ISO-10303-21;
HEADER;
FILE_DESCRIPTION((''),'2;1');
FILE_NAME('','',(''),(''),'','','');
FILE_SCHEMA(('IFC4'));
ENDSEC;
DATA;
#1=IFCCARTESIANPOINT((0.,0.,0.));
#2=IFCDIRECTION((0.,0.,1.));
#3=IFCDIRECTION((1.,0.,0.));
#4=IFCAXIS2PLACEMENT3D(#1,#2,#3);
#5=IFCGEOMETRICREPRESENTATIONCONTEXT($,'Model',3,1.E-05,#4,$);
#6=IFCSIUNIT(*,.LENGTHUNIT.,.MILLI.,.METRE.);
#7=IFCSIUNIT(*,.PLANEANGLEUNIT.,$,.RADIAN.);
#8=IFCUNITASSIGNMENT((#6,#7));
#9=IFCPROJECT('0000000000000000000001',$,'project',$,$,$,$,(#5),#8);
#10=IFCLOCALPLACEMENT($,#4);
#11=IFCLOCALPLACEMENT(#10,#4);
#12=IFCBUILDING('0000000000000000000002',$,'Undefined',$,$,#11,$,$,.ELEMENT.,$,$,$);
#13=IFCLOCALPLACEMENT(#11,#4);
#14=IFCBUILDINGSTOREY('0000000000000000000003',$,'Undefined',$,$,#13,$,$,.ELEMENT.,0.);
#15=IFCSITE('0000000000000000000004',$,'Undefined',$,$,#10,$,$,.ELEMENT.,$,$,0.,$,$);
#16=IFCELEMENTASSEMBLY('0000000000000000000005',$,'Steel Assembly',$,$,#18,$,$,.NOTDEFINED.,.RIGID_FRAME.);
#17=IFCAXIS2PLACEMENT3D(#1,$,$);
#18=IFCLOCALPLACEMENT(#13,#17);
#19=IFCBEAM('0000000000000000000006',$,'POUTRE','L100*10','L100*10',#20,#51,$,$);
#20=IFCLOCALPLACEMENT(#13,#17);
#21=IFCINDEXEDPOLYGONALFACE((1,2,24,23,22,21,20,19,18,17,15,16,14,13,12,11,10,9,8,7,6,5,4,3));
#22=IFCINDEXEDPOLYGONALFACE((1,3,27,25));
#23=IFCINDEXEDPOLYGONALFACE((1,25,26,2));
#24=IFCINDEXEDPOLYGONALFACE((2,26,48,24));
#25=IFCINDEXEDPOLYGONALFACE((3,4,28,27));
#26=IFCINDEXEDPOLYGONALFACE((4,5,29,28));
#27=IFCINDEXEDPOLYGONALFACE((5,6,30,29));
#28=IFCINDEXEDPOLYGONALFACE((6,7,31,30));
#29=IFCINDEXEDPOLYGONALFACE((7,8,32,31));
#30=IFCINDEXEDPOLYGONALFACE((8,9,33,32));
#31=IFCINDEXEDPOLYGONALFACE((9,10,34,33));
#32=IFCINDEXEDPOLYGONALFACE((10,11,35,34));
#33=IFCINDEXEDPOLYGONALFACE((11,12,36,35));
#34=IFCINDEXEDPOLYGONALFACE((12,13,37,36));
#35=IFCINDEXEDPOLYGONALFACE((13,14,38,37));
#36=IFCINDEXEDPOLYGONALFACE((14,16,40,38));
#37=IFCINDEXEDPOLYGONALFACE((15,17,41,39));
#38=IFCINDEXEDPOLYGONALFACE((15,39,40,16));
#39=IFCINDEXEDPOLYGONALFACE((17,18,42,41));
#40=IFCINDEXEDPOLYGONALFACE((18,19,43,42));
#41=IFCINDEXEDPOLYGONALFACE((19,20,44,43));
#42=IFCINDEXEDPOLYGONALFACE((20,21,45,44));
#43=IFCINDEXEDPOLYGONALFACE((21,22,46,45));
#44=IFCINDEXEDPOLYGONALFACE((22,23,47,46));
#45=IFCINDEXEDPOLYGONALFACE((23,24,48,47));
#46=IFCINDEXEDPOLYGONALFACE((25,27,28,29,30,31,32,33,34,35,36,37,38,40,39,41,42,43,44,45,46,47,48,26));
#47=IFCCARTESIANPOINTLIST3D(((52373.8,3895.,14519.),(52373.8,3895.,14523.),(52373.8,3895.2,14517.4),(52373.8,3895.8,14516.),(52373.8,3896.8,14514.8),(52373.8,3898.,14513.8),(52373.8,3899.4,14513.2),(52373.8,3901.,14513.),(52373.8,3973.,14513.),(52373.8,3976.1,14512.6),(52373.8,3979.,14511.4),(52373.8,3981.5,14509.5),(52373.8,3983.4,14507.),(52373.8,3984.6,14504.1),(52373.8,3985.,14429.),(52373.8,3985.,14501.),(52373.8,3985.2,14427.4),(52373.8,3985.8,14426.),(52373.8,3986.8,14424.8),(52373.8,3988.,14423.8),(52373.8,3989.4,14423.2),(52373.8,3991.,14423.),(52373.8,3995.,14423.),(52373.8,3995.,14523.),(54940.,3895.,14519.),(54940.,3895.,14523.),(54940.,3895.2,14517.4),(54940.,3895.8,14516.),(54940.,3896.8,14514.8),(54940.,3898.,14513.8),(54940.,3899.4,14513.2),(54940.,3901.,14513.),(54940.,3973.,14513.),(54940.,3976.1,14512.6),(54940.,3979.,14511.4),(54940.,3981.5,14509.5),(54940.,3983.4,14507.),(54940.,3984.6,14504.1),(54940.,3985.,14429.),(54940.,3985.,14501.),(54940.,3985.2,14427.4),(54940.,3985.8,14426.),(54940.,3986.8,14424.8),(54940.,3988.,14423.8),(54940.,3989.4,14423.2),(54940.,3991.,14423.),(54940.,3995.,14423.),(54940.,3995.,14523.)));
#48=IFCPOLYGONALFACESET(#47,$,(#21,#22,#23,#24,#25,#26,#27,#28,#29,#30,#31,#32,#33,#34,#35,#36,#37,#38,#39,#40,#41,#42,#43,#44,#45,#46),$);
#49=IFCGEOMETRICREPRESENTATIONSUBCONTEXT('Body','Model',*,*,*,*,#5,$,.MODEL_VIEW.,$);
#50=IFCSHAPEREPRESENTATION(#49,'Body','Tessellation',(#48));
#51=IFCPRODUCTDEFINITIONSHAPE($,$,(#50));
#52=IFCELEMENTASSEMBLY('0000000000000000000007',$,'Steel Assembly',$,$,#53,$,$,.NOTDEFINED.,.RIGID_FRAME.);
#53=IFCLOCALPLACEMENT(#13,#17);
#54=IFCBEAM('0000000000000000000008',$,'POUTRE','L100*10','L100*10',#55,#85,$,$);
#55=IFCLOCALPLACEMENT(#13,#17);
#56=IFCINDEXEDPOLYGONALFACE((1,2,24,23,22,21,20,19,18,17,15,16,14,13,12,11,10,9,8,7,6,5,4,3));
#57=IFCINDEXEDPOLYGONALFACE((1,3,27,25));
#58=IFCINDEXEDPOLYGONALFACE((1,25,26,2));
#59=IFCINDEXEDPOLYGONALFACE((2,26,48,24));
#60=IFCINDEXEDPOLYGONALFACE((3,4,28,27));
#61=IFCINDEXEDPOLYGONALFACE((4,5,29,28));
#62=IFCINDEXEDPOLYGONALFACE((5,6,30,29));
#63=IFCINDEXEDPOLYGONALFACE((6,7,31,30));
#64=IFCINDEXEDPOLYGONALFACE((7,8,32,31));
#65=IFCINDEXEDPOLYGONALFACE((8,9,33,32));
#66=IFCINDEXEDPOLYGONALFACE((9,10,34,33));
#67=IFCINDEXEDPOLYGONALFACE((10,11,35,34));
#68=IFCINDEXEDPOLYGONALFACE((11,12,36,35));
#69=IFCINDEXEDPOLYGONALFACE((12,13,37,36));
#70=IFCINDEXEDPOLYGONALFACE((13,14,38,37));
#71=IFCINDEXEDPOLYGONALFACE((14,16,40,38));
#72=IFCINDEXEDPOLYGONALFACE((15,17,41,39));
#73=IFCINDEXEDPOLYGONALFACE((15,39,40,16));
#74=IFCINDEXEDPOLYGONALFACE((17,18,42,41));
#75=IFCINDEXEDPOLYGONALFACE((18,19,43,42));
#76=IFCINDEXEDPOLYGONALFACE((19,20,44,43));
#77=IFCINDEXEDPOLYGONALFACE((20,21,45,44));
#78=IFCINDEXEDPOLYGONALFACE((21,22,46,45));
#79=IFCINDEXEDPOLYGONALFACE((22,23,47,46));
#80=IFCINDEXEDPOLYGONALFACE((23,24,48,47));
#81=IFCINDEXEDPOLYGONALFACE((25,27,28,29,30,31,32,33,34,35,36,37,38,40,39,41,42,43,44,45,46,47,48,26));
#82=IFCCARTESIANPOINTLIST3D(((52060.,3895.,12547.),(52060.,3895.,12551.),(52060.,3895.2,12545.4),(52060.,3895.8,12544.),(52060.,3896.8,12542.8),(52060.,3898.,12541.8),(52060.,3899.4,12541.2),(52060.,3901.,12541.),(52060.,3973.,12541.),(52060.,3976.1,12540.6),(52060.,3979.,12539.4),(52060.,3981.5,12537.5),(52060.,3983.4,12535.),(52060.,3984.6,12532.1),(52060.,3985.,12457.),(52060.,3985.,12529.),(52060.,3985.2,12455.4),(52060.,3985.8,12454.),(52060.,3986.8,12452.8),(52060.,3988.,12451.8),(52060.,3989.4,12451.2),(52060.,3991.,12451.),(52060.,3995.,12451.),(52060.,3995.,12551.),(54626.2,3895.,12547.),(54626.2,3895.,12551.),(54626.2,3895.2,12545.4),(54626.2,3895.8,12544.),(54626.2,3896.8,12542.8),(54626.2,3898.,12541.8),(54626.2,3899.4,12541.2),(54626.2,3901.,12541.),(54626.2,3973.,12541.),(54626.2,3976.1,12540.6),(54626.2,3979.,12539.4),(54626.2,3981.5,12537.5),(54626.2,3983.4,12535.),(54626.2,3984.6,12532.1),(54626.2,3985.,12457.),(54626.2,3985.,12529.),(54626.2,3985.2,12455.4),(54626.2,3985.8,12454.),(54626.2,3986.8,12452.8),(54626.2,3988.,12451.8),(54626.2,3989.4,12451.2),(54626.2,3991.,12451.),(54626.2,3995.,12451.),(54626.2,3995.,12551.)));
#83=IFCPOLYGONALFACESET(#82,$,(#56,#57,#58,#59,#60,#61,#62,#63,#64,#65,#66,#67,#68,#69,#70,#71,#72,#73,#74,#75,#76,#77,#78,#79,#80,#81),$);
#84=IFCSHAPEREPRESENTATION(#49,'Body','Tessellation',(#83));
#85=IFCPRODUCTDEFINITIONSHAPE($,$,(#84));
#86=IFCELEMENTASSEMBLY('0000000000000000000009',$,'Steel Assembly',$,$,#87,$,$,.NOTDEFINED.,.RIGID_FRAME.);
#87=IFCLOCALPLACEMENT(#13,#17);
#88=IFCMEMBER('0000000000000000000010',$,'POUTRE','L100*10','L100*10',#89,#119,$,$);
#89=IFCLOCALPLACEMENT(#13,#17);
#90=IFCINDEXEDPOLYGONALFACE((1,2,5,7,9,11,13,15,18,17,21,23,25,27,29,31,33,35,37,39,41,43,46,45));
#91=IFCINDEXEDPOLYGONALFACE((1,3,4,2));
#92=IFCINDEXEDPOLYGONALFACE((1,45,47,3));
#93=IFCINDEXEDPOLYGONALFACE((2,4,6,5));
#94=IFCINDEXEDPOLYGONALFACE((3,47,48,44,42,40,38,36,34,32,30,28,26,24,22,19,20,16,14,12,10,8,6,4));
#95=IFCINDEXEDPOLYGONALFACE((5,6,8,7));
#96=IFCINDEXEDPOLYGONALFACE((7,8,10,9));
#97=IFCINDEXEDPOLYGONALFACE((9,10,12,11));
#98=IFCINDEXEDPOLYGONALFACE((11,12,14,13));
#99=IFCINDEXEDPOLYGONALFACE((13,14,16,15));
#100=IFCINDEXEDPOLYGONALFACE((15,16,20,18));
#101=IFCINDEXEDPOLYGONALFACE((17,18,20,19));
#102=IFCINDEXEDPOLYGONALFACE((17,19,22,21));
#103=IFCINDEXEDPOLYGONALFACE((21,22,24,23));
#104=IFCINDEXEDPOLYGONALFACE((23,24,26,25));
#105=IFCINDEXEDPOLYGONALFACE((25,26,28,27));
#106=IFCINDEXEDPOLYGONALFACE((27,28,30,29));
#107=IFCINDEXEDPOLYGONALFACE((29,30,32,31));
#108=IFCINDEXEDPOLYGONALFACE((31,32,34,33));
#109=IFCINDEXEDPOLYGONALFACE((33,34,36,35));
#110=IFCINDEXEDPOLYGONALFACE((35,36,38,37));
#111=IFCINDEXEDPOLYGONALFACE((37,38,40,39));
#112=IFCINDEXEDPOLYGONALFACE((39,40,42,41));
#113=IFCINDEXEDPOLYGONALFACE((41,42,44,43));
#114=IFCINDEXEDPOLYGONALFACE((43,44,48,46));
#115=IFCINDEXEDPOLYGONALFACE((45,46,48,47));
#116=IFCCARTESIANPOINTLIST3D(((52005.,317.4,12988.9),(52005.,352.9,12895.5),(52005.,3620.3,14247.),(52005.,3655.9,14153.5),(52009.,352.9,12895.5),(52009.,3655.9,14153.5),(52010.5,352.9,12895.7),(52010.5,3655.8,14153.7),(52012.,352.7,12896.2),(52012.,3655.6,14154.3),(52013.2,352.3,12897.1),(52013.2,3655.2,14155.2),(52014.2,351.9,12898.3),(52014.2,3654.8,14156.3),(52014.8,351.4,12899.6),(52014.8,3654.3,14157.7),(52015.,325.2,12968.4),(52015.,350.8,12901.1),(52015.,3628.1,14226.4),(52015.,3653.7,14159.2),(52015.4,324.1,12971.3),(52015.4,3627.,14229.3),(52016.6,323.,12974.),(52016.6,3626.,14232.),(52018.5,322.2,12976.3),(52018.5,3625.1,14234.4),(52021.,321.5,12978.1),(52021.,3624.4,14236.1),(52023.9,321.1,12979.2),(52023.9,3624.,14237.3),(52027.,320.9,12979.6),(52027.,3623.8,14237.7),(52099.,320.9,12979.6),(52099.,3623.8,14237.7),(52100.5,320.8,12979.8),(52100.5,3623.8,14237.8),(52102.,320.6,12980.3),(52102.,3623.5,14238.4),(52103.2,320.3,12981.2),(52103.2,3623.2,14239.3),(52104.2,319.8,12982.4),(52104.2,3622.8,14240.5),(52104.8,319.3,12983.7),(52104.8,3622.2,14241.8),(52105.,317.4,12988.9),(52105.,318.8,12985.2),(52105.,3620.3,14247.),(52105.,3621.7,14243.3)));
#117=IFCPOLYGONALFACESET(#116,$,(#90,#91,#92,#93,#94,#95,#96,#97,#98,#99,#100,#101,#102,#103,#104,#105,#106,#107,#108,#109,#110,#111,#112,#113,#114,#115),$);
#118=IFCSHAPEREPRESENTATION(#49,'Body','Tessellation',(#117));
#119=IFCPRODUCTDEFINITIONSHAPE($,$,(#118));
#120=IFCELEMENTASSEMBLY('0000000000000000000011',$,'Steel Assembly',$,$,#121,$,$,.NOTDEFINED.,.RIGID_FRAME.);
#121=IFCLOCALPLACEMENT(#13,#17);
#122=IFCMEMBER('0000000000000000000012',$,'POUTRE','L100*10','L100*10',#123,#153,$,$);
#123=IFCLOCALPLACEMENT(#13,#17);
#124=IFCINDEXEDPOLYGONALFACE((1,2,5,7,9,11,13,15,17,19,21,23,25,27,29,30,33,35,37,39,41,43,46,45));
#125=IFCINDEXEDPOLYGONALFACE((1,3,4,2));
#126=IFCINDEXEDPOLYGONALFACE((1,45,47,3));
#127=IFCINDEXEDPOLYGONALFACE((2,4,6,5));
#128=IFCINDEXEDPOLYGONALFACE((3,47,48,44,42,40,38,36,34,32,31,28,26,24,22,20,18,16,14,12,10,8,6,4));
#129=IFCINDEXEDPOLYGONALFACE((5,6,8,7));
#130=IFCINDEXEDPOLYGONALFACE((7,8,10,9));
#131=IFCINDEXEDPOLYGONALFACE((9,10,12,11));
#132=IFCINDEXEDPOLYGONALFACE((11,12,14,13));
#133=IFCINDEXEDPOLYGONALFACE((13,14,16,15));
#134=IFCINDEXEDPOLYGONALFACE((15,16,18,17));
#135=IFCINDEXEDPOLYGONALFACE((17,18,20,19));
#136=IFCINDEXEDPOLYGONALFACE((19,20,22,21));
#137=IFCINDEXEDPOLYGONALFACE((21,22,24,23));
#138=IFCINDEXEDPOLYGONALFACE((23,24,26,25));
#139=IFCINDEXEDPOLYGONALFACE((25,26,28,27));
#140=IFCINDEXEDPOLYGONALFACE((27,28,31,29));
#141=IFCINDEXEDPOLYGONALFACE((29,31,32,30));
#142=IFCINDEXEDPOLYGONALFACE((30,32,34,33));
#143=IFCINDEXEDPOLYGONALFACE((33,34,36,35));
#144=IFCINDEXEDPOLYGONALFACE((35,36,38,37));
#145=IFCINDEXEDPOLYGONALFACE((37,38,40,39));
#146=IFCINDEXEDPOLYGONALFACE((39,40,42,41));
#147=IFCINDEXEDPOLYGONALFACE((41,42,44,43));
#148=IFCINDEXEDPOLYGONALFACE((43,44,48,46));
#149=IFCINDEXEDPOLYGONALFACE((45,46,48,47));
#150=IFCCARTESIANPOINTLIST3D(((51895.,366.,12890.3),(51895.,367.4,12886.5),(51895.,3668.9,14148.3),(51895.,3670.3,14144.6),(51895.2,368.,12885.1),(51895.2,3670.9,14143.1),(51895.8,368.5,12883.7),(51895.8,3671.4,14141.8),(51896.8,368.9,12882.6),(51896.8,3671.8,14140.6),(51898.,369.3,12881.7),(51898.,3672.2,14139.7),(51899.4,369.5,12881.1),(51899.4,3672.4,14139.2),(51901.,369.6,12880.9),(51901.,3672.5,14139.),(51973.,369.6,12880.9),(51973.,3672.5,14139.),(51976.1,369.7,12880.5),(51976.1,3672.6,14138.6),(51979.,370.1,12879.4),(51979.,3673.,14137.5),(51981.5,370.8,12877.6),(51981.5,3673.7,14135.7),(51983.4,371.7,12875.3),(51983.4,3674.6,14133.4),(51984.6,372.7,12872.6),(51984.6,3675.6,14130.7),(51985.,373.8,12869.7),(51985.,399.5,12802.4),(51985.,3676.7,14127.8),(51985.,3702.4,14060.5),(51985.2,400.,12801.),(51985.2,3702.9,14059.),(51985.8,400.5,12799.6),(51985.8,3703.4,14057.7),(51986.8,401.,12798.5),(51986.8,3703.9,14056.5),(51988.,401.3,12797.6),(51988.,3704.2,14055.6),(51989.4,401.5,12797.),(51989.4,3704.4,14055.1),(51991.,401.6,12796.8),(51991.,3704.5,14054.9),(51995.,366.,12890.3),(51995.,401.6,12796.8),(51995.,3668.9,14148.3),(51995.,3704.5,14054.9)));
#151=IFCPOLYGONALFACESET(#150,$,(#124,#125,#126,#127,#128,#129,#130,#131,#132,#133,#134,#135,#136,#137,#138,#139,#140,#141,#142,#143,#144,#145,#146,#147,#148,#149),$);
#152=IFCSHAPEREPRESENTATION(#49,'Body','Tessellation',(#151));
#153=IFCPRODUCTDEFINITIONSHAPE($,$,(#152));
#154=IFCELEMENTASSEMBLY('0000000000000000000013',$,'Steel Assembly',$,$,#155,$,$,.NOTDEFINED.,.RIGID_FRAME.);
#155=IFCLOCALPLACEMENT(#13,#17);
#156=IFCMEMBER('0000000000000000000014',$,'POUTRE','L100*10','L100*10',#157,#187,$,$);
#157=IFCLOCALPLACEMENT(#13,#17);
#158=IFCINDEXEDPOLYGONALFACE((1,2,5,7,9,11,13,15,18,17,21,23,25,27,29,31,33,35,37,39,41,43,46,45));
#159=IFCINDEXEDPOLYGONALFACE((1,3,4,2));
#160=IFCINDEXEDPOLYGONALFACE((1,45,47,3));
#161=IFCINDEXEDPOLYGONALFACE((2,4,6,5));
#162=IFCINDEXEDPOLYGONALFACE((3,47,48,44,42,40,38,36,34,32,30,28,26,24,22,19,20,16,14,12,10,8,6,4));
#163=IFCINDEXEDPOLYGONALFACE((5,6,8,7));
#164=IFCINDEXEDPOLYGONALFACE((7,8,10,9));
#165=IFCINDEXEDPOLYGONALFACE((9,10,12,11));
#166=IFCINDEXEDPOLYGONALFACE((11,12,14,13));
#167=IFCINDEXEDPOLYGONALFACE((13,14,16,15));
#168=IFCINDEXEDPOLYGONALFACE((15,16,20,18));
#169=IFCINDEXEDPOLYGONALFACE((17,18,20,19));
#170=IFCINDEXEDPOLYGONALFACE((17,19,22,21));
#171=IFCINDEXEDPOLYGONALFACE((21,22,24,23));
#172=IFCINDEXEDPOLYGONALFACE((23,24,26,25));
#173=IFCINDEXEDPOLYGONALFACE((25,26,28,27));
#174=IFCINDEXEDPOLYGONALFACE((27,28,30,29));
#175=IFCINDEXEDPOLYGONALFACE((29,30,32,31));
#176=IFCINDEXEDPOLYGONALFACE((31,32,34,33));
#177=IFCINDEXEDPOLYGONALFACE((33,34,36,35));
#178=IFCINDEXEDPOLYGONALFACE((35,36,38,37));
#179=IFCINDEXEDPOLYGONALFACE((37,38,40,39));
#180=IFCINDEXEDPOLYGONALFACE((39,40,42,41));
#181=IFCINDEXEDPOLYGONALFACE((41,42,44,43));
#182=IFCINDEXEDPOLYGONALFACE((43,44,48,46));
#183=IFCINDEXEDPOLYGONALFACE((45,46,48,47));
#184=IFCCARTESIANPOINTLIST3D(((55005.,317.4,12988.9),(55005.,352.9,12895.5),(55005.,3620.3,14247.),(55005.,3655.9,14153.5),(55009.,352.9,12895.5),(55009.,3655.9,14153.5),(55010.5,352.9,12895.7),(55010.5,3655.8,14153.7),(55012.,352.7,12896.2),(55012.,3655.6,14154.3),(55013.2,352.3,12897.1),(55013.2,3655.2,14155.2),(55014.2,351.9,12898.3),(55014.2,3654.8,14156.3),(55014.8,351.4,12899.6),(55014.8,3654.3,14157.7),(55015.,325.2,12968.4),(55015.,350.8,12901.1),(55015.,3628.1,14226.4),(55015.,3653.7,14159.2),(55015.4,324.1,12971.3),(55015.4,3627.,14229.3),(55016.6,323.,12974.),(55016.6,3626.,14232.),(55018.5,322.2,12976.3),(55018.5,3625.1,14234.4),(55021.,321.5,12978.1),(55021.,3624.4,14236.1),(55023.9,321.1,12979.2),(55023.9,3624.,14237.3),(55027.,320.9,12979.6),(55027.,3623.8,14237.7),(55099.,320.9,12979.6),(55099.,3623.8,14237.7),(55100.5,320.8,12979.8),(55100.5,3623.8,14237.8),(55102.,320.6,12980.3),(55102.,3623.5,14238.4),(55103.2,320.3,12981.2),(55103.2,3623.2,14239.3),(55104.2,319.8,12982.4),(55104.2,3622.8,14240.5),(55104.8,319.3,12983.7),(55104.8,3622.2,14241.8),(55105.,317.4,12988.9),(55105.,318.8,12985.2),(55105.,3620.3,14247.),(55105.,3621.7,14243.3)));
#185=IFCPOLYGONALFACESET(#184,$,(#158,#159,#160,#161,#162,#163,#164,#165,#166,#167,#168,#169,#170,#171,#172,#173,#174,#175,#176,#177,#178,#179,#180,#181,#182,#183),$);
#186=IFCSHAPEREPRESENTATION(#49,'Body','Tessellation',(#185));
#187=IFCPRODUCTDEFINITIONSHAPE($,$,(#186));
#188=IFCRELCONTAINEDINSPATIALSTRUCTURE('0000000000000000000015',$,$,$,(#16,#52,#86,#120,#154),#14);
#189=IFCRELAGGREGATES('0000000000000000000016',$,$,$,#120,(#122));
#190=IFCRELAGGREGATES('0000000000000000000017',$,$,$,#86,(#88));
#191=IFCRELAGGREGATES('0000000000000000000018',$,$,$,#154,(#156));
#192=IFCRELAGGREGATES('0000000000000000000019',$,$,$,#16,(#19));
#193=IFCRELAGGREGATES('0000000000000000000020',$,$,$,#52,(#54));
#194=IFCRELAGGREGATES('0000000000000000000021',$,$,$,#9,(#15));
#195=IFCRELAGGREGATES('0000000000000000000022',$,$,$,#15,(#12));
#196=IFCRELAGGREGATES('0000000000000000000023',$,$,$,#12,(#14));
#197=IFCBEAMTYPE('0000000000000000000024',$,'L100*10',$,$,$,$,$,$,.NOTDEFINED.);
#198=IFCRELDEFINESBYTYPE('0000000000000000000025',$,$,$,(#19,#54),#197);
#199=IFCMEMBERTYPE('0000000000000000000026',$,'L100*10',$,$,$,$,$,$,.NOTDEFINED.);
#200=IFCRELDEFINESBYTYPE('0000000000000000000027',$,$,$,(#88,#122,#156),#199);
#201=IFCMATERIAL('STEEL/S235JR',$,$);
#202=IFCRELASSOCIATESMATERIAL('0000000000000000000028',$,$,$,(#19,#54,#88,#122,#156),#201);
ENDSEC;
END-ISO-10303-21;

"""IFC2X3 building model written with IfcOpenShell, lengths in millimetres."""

from ifc_helpers import new_model, si_unit, frame, origin_with_axes, origin_2d_with_axis, place, context, subcontext, project, spatial, l_section, extrude, material, type_object, element, aggregate, save


model = new_model("IFC2X3")

# Units and contexts
model_context = context("Model", 3, precision=1e-05, world=origin_with_axes())
body_context = subcontext(model_context, "Body", "Model", "MODEL_VIEW")
ifc_project = project(units=[si_unit("LENGTHUNIT", "METRE", prefix="MILLI"), si_unit("PLANEANGLEUNIT", "RADIAN")], contexts=[model_context])

# Site, building, storey
site_placement = place(None, origin_with_axes())
site = spatial("IfcSite", under=ifc_project, at=site_placement, Name="Undefined", CompositionType="ELEMENT", RefElevation=0.0)
building_placement = place(site_placement, origin_with_axes())
building = spatial("IfcBuilding", under=site, at=building_placement, Name="Undefined", CompositionType="ELEMENT")
storey_placement = place(building_placement, origin_with_axes())
storey = spatial("IfcBuildingStorey", under=building, at=storey_placement, Name="Undefined", CompositionType="ELEMENT", Elevation=0.0)

# Element assemblies, beams
assembly_1_placement = place(storey_placement, origin_with_axes())
assembly_1 = element("IfcElementAssembly", 1, at=assembly_1_placement, inside=storey, Name="Steel Assembly", AssemblyPlace="NOTDEFINED", PredefinedType="RIGID_FRAME")
ifc_material_1 = material(Name="STEEL/S235JR")
beam_type = type_object("IfcBeamType", Name="L100*10", PredefinedType="NOTDEFINED")
beam_1_placement = place(assembly_1_placement, frame((52373.8, 3945.0, 14473.0), z_axis=(0.0, -1.0, 0.0), x_axis=(1.0, 0.0, 0.0)))
beam_1 = element("IfcBeam", 2, at=beam_1_placement, type_object=beam_type, material=ifc_material_1, Name="POUTRE", Description="L100*10", ObjectType="L100*10", context=body_context, shape_type="SweptSolid", body=[
    extrude(l_section(Depth=100.0, Width=100.0, Thickness=10.0, FilletRadius=12.0, EdgeRadius=6.0, at=origin_2d_with_axis()), frame((2566.2, 0.0, 0.0), z_axis=(-1.0, 0.0, 0.0), x_axis=(0.0, -1.0, 0.0)), (0.0, 0.0, 1.0), 2566.2),
])
assembly_2_placement = place(storey_placement, origin_with_axes())
assembly_2 = element("IfcElementAssembly", 3, at=assembly_2_placement, inside=storey, Name="Steel Assembly", AssemblyPlace="NOTDEFINED", PredefinedType="RIGID_FRAME")
beam_2_placement = place(assembly_2_placement, frame((52060.0, 3945.0, 12501.0), z_axis=(0.0, -1.0, 0.0), x_axis=(1.0, 0.0, 0.0)))
beam_2 = element("IfcBeam", 4, at=beam_2_placement, type_object=beam_type, material=ifc_material_1, Name="POUTRE", Description="L100*10", ObjectType="L100*10", context=body_context, shape_type="SweptSolid", body=[
    extrude(l_section(Depth=100.0, Width=100.0, Thickness=10.0, FilletRadius=12.0, EdgeRadius=6.0, at=origin_2d_with_axis()), frame((2566.2, 0.0, 0.0), z_axis=(-1.0, 0.0, 0.0), x_axis=(0.0, -1.0, 0.0)), (0.0, 0.0, 1.0), 2566.2),
])

# Element assemblies, members
assembly_3_placement = place(storey_placement, origin_with_axes())
assembly_3 = element("IfcElementAssembly", 5, at=assembly_3_placement, inside=storey, Name="Steel Assembly", AssemblyPlace="NOTDEFINED", PredefinedType="RIGID_FRAME")
member_type = type_object("IfcMemberType", Name="L100*10", PredefinedType="NOTDEFINED")
member_1_placement = place(assembly_3_placement, frame((52055.0, 3638.1, 14200.3), z_axis=(0.0, 0.355951, -0.934505), x_axis=(0.0, -0.934505, -0.355951)))
member_1 = element("IfcMember", 6, at=member_1_placement, type_object=member_type, material=ifc_material_1, Name="POUTRE", Description="L100*10", ObjectType="L100*10", context=body_context, shape_type="SweptSolid", body=[
    extrude(l_section(Depth=100.0, Width=100.0, Thickness=10.0, FilletRadius=12.0, EdgeRadius=6.0, at=origin_2d_with_axis()), frame((3534.4, 0.0, 0.0), z_axis=(-1.0, 0.0, 0.0), x_axis=(0.0, -1.0, 0.0)), (0.0, 0.0, 1.0), 3534.4),
])
assembly_4_placement = place(storey_placement, origin_with_axes())
assembly_4 = element("IfcElementAssembly", 7, at=assembly_4_placement, inside=storey, Name="Steel Assembly", AssemblyPlace="NOTDEFINED", PredefinedType="RIGID_FRAME")
member_2_placement = place(assembly_4_placement, frame((51945.0, 3686.7, 14101.6), z_axis=(-1.0, 0.0, 0.0), x_axis=(0.0, -0.934505, -0.355951)))
member_2 = element("IfcMember", 8, at=member_2_placement, type_object=member_type, material=ifc_material_1, Name="POUTRE", Description="L100*10", ObjectType="L100*10", context=body_context, shape_type="SweptSolid", body=[
    extrude(l_section(Depth=100.0, Width=100.0, Thickness=10.0, FilletRadius=12.0, EdgeRadius=6.0, at=origin_2d_with_axis()), frame((3534.4, 0.0, 0.0), z_axis=(-1.0, 0.0, 0.0), x_axis=(0.0, -1.0, 0.0)), (0.0, 0.0, 1.0), 3534.4),
])
assembly_5_placement = place(storey_placement, origin_with_axes())
assembly_5 = element("IfcElementAssembly", 9, at=assembly_5_placement, inside=storey, Name="Steel Assembly", AssemblyPlace="NOTDEFINED", PredefinedType="RIGID_FRAME")
member_3_placement = place(assembly_5_placement, frame((55055.0, 3638.1, 14200.3), z_axis=(0.0, 0.355951, -0.934505), x_axis=(0.0, -0.934505, -0.355951)))
member_3 = element("IfcMember", 10, at=member_3_placement, type_object=member_type, material=ifc_material_1, Name="POUTRE", Description="L100*10", ObjectType="L100*10", context=body_context, shape_type="SweptSolid", body=[
    extrude(l_section(Depth=100.0, Width=100.0, Thickness=10.0, FilletRadius=12.0, EdgeRadius=6.0, at=origin_2d_with_axis()), frame((3534.4, 0.0, 0.0), z_axis=(-1.0, 0.0, 0.0), x_axis=(0.0, -1.0, 0.0)), (0.0, 0.0, 1.0), 3534.4),
])

aggregate(assembly_4, [member_2])

aggregate(assembly_3, [member_1])

aggregate(assembly_5, [member_3])

aggregate(assembly_1, [beam_1])
aggregate(assembly_2, [beam_2])

save(model, "model.ifc")
